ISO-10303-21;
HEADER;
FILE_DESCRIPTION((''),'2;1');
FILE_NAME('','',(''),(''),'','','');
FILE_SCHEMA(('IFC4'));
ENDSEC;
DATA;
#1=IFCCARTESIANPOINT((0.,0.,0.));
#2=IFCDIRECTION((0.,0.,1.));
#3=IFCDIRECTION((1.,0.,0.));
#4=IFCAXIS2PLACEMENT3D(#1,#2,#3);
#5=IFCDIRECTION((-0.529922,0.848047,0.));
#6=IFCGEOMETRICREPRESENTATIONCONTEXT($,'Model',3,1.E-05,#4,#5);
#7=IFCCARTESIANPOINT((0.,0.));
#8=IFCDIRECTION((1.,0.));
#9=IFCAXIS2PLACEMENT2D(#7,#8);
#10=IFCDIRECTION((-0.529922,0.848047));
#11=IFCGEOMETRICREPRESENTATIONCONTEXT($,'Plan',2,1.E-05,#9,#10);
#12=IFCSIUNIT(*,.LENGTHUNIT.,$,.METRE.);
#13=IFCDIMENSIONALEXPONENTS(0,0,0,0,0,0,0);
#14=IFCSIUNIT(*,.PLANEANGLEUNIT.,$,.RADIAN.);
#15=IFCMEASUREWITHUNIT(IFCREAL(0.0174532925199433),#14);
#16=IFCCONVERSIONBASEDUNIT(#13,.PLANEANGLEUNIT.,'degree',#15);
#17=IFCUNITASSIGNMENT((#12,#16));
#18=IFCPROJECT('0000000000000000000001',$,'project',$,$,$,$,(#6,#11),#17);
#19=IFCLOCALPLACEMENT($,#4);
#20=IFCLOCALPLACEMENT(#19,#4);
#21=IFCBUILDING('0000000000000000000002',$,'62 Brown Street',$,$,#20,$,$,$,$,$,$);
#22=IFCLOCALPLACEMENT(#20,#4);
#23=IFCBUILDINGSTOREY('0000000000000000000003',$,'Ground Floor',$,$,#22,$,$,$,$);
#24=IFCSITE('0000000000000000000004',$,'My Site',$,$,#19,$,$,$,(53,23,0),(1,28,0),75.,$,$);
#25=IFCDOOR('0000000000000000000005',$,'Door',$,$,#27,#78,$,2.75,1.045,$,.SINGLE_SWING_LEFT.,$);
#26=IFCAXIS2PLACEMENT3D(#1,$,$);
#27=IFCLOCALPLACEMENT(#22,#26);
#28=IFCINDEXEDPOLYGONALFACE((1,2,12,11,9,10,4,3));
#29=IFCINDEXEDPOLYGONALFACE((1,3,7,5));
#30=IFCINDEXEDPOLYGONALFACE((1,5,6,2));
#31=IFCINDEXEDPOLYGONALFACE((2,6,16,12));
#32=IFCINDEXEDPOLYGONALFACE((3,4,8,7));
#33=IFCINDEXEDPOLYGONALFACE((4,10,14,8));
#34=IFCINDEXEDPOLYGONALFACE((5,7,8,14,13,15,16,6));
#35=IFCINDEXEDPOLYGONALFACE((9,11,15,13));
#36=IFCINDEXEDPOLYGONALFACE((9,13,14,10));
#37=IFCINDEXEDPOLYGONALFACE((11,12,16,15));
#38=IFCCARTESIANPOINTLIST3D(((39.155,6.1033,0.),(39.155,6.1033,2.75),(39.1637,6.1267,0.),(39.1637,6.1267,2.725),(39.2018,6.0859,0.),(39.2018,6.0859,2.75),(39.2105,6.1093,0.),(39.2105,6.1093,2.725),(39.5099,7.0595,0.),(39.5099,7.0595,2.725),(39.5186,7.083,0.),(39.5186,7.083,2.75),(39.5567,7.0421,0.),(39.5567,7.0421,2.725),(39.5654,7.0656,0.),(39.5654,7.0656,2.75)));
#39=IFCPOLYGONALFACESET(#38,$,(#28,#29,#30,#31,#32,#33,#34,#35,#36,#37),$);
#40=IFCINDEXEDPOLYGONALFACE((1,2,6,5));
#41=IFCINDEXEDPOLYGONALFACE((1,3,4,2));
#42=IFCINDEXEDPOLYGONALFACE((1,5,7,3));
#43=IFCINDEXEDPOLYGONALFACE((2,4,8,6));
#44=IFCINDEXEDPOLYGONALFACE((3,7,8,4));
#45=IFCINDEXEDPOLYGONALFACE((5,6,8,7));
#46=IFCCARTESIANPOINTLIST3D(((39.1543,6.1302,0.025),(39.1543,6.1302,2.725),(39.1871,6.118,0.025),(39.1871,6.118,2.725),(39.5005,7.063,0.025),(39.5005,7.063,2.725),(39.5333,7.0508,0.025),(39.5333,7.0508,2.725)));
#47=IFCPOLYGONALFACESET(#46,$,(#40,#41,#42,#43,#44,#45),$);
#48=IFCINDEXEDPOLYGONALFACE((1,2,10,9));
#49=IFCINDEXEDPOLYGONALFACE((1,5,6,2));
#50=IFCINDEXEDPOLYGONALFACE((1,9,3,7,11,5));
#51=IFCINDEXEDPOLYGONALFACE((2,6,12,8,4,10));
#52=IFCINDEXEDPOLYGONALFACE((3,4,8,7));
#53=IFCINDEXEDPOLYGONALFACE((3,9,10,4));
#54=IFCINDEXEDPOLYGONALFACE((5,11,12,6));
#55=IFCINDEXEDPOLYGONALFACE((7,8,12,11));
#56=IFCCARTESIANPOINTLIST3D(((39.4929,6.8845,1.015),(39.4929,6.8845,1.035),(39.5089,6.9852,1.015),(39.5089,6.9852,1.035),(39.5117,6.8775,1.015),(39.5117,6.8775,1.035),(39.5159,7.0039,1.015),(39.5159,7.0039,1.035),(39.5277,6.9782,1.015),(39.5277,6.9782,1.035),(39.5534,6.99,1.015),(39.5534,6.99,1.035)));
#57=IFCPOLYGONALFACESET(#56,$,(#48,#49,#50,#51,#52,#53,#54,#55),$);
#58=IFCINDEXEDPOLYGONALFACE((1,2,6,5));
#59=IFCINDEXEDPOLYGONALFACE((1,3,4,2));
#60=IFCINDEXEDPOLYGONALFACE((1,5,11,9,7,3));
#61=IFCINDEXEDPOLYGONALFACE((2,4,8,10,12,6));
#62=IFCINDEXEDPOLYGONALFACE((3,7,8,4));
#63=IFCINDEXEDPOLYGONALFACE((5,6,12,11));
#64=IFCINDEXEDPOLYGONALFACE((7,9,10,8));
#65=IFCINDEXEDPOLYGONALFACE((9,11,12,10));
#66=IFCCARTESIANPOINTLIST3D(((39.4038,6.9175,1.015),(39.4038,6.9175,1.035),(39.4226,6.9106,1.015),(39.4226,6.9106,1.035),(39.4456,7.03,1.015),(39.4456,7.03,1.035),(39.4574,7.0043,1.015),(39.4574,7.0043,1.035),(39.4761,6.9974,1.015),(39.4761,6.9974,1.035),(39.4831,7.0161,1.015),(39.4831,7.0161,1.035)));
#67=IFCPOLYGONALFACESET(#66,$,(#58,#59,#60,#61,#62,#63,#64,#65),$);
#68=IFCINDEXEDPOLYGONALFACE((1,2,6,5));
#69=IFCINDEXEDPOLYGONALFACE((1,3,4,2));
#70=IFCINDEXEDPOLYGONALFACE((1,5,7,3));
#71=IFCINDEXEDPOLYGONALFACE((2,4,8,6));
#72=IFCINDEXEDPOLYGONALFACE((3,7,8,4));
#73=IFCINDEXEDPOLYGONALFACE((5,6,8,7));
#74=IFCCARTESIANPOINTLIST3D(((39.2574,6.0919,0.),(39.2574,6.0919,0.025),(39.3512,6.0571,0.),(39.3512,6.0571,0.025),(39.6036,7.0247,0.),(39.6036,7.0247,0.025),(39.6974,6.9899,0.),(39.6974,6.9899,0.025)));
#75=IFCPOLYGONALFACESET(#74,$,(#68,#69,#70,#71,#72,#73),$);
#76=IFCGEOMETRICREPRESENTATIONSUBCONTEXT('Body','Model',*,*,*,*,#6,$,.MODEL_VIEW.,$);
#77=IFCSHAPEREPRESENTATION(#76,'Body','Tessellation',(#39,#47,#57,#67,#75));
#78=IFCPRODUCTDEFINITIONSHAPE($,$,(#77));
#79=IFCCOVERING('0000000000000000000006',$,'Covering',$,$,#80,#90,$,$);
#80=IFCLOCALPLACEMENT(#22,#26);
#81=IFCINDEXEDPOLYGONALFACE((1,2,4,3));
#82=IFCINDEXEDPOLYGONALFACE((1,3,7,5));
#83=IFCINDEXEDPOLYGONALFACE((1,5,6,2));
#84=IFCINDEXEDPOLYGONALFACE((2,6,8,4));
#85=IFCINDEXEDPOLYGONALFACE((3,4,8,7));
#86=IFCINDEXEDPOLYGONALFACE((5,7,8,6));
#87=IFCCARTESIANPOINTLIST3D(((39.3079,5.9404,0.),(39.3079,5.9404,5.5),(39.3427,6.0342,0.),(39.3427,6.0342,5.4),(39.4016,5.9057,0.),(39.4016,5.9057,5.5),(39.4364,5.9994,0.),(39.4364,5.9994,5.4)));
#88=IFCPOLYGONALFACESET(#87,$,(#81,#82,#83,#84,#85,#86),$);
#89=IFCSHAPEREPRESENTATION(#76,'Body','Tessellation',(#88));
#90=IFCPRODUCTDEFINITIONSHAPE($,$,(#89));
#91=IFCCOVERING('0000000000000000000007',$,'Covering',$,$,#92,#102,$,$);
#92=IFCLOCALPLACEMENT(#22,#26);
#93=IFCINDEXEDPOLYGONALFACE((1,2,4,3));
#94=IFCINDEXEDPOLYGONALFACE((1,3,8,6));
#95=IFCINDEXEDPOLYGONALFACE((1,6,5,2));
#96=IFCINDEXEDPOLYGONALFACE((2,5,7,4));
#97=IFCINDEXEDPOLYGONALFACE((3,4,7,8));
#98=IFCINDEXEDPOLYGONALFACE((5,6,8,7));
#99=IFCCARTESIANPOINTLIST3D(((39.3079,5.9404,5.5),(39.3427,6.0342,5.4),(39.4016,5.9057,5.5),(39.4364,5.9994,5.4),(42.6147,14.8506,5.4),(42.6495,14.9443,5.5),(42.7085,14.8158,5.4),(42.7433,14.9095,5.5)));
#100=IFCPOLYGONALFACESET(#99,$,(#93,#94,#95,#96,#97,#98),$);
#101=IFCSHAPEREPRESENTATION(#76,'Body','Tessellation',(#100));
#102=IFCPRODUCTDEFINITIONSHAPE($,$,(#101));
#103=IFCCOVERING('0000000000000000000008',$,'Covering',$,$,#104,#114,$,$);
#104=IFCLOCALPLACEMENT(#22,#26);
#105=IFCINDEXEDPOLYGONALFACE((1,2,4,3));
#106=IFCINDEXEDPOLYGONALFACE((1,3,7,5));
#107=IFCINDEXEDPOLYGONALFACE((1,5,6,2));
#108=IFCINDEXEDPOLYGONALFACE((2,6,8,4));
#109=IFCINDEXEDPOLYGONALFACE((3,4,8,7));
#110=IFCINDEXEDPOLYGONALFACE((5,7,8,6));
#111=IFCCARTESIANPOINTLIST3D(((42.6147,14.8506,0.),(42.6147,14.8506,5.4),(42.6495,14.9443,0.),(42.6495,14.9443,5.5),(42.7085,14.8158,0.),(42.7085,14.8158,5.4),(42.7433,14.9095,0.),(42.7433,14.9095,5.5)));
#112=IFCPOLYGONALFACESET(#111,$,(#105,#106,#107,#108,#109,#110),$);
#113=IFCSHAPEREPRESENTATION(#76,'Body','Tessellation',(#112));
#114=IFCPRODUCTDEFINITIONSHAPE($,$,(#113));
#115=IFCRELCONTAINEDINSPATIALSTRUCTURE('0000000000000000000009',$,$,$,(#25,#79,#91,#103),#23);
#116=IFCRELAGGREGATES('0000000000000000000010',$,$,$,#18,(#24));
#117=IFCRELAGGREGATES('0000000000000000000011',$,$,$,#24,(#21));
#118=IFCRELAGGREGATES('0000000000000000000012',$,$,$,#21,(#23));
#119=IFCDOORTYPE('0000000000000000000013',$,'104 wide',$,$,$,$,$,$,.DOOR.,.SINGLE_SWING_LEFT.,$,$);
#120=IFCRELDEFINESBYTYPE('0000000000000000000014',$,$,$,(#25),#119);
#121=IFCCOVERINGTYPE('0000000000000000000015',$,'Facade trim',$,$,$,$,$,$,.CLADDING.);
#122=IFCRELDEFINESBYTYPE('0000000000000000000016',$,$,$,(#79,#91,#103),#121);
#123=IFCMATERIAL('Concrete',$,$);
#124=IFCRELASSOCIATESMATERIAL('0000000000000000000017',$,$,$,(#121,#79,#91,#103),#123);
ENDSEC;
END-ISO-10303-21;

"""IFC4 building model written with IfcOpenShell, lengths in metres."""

from ifc_helpers import new_model, entity, si_unit, converted_unit, direction, frame, origin_with_axes, origin_2d_with_axis, place, context, subcontext, project, spatial, line, indexed_curve, rectangle, outline, extrude, clip, halfspace, shape, source, transform, mapped, material, material_profile, profile_set, profile_usage, type_object, type_shapes, element, save


model = new_model("IFC4")

# Units and contexts
model_context = context("Model", 3, precision=1e-05, world=origin_with_axes(), true_north=direction((-0.529922, 0.848047, 0.0)))
plan_context = context("Plan", 2, precision=1e-05, world=origin_2d_with_axis(), true_north=direction((-0.529922, 0.848047)))
body_context_1 = subcontext(model_context, "Body", "Model", "MODEL_VIEW")
body_context_2 = subcontext(plan_context, "Body", "Plan", "PLAN_VIEW")
ifc_project = project(units=[si_unit("LENGTHUNIT", "METRE"), converted_unit("PLANEANGLEUNIT", "degree", entity("IfcReal", 0.0174532925199433), si_unit("PLANEANGLEUNIT", "RADIAN"), dimensions=[0, 0, 0, 0, 0, 0, 0])], contexts=[model_context, plan_context])

# Site, building, storey
site_placement = place(None, origin_with_axes())
site = spatial("IfcSite", under=ifc_project, at=site_placement, Name="My Site", RefLatitude=(53, 23, 0), RefLongitude=(1, 28, 0), RefElevation=75.0)
building_placement = place(site_placement, origin_with_axes())
building = spatial("IfcBuilding", under=site, at=building_placement, Name="62 Brown Street")
storey_placement = place(building_placement, origin_with_axes())
storey = spatial("IfcBuildingStorey", under=building, at=storey_placement, Name="Ground Floor")

# Shared definitions
ifc_material_1 = material(Name="Concrete")

# Shared definitions
placement_1 = place(storey_placement, frame((39.024, 5.1755, 0.0), z_axis=(0.0, 0.0, 1.0), x_axis=(0.347944, 0.937515, 0.0)))

# Door
door_type_1 = type_object("IfcDoorType", Name="104 wide", OperationType="SINGLE_SWING_LEFT", PredefinedType="DOOR")
shared_shape_1 = source(origin_with_axes(), body_context_1, "Body", "SweptSolid", [
    extrude(outline(indexed_curve([(0.0, 0.0), (0.0, 2.75), (1.045, 2.75), (1.045, 0.0), (1.02, 0.0), (1.02, 2.725), (0.025, 2.725), (0.025, 0.0)], segments=[line(1, 2, 3, 4, 5, 6, 7, 8, 1)])), frame((0.0, 0.15, 0.0), z_axis=(0.0, -1.0, 0.0), x_axis=(1.0, 0.0, 0.0)), (0.0, 0.0, -1.0), 0.05),
    extrude(outline(indexed_curve([(0.0, 0.0), (0.995, 0.0), (0.995, 0.035), (0.0, 0.035)], segments=[line(1, 2, 3, 4, 1)])), frame((0.025, 0.175, 0.025), z_axis=(0.0, 0.0, 1.0), x_axis=(1.0, 0.0, 0.0)), (0.0, 0.0, 1.0), 2.7),
    extrude(outline(indexed_curve([(0.0, 0.0), (0.0, -0.04), (-0.12, -0.04), (-0.12, -0.02), (-0.02, -0.02), (-0.02, 0.0)], segments=[line(1, 2, 3, 4, 5, 6, 1)])), frame((0.97, 0.175, 1.015), z_axis=(0.0, 0.0, 1.0), x_axis=(1.0, 0.0, 0.0)), (0.0, 0.0, 1.0), 0.02),
    extrude(outline(indexed_curve([(0.0, 0.0), (0.0, 0.04), (-0.12, 0.04), (-0.12, 0.02), (-0.02, 0.02), (-0.02, 0.0)], segments=[line(1, 2, 3, 4, 5, 6, 1)])), frame((0.97, 0.21, 1.015), z_axis=(0.0, 0.0, 1.0), x_axis=(1.0, 0.0, 0.0)), (0.0, 0.0, 1.0), 0.02),
    extrude(outline(indexed_curve([(0.0, 0.0), (0.995, 0.0), (0.995, 0.1), (0.0, 0.1)], segments=[line(1, 2, 3, 4, 1)])), frame((0.025, 0.0, 0.0), z_axis=(0.0, 0.0, 1.0), x_axis=(1.0, 0.0, 0.0)), (0.0, 0.0, 1.0), 0.025),
])
shared_shape_2 = source(origin_with_axes(), body_context_2, "Body", "Curve2D", [
    entity("IfcIndexedPolyCurve", entity("IfcCartesianPointList2D", [[0.0, 0.15], [0.025, 0.15], [0.025, 0.2], [0.0, 0.2]]), [entity("IfcLineIndex", [1, 2, 3, 4, 1])]),
    entity("IfcIndexedPolyCurve", entity("IfcCartesianPointList2D", [[1.045, 0.15], [1.02, 0.15], [1.02, 0.2], [1.045, 0.2]]), [entity("IfcLineIndex", [1, 2, 3, 4, 1])]),
    entity("IfcTrimmedCurve", entity("IfcEllipse", entity("IfcAxis2Placement2D", entity("IfcCartesianPoint", [0.06, 0.2]), entity("IfcDirection", [1.0, 0.0])), 0.96, 0.995), [entity("IfcCartesianPoint", [1.02, 0.2])], [entity("IfcCartesianPoint", [0.06, 1.195])], True, "CARTESIAN"),
    entity("IfcIndexedPolyCurve", entity("IfcCartesianPointList2D", [[0.025, 0.2], [0.06, 0.2], [0.06, 1.195], [0.025, 1.195]]), [entity("IfcLineIndex", [1, 2, 3, 4, 1])]),
])
type_shapes(door_type_1, [shared_shape_1, shared_shape_2])
placement_2 = place(placement_1, frame((0.9154, 0.0, 0.0), z_axis=(0.0, 0.0, 1.0), x_axis=(1.0, 0.0, 0.0)))
door_1_placement = place(placement_2, frame((0.0, 0.0, 0.0), z_axis=(0.0, 0.0, 1.0), x_axis=(1.0, 0.0, 0.0)))
element("IfcDoor", 1, at=door_1_placement, inside=storey, type_object=door_type_1, Name="Door", OperationType="SINGLE_SWING_LEFT", OverallHeight=2.75, OverallWidth=1.045, shapes=[
    shape(body_context_1, "Body", "MappedRepresentation", [mapped(shared_shape_1, transform((0.0, 0.0, 0.0), x_axis=(1.0, 0.0, 0.0), y_axis=(0.0, 1.0, 0.0), z_axis=(0.0, 0.0, 1.0), scale=1.0))]),
    shape(body_context_2, "Body", "MappedRepresentation", [mapped(shared_shape_2, transform((0.0, 0.0, 0.0), x_axis=(1.0, 0.0, 0.0), y_axis=(0.0, 1.0, 0.0), z_axis=(0.0, 0.0, 1.0), scale=1.0))]),
])

# Coverings
ifc_material_profile_1 = material_profile(ifc_material_1, rectangle(XDim=0.1, YDim=0.1))
ifc_profile_set_1 = profile_set([ifc_material_profile_1], Name="cowl")
ifc_profile_usage_1 = profile_usage(ifc_profile_set_1, cardinal=5)
covering_type = type_object("IfcCoveringType", Name="Facade trim", PredefinedType="CLADDING", material=ifc_profile_set_1)
covering_1_placement = place(storey_placement, frame((39.3721, 5.9699, 0.0), z_axis=(0.0, 0.0, 1.0), x_axis=(0.347944, 0.937515, 0.0)))
element("IfcCovering", 2, at=covering_1_placement, inside=storey, type_object=covering_type, material=ifc_profile_usage_1, Name="Covering", context=body_context_1, shape_type="Clipping", body=[
    clip(extrude(rectangle(XDim=0.1, YDim=0.1), origin_with_axes(), (0.0, 0.0, 1.0), 5.5), halfspace(frame((-0.05, 34.8348, 5.5), z_axis=(0.707098, 0.0, 0.707116), x_axis=(0.707116, 0.0, -0.707098)), False)),
])
ifc_profile_usage_2 = profile_usage(ifc_profile_set_1, cardinal=5)
covering_2_placement = place(storey_placement, frame((39.3547, 5.923, 5.45), z_axis=(0.347944, 0.937515, 0.0), x_axis=(0.0, 0.0, -1.0)))
element("IfcCovering", 3, at=covering_2_placement, inside=storey, type_object=covering_type, material=ifc_profile_usage_2, Name="Covering", context=body_context_1, shape_type="Clipping", body=[
    clip(clip(extrude(rectangle(XDim=0.1, YDim=0.1), origin_with_axes(), (0.0, 0.0, 1.0), 9.604), halfspace(frame((-0.05, 34.8348, 9.604), z_axis=(0.707114, 0.0, 0.7071), x_axis=(0.7071, -0.000003, -0.707113)), False)), halfspace(frame((-0.05, 34.8348, 0.0), z_axis=(0.707116, 0.0, -0.707098), x_axis=(0.707098, 0.0, 0.707116)), False)),
])
ifc_profile_usage_3 = profile_usage(ifc_profile_set_1, cardinal=5)
covering_3_placement = place(storey_placement, frame((42.679, 14.8801, 5.5), z_axis=(0.0, 0.0, -1.0), x_axis=(-0.347944, -0.937515, 0.0)))
element("IfcCovering", 4, at=covering_3_placement, inside=storey, type_object=covering_type, material=ifc_profile_usage_3, Name="Covering", context=body_context_1, shape_type="Clipping", body=[
    clip(extrude(rectangle(XDim=0.1, YDim=0.1), origin_with_axes(), (0.0, 0.0, 1.0), 5.5), halfspace(frame((-0.05, 34.8348, 0.0), z_axis=(0.7071, 0.0, -0.707113), x_axis=(0.707113, -0.000003, 0.7071)), False)),
])

save(model, "model.ifc")
